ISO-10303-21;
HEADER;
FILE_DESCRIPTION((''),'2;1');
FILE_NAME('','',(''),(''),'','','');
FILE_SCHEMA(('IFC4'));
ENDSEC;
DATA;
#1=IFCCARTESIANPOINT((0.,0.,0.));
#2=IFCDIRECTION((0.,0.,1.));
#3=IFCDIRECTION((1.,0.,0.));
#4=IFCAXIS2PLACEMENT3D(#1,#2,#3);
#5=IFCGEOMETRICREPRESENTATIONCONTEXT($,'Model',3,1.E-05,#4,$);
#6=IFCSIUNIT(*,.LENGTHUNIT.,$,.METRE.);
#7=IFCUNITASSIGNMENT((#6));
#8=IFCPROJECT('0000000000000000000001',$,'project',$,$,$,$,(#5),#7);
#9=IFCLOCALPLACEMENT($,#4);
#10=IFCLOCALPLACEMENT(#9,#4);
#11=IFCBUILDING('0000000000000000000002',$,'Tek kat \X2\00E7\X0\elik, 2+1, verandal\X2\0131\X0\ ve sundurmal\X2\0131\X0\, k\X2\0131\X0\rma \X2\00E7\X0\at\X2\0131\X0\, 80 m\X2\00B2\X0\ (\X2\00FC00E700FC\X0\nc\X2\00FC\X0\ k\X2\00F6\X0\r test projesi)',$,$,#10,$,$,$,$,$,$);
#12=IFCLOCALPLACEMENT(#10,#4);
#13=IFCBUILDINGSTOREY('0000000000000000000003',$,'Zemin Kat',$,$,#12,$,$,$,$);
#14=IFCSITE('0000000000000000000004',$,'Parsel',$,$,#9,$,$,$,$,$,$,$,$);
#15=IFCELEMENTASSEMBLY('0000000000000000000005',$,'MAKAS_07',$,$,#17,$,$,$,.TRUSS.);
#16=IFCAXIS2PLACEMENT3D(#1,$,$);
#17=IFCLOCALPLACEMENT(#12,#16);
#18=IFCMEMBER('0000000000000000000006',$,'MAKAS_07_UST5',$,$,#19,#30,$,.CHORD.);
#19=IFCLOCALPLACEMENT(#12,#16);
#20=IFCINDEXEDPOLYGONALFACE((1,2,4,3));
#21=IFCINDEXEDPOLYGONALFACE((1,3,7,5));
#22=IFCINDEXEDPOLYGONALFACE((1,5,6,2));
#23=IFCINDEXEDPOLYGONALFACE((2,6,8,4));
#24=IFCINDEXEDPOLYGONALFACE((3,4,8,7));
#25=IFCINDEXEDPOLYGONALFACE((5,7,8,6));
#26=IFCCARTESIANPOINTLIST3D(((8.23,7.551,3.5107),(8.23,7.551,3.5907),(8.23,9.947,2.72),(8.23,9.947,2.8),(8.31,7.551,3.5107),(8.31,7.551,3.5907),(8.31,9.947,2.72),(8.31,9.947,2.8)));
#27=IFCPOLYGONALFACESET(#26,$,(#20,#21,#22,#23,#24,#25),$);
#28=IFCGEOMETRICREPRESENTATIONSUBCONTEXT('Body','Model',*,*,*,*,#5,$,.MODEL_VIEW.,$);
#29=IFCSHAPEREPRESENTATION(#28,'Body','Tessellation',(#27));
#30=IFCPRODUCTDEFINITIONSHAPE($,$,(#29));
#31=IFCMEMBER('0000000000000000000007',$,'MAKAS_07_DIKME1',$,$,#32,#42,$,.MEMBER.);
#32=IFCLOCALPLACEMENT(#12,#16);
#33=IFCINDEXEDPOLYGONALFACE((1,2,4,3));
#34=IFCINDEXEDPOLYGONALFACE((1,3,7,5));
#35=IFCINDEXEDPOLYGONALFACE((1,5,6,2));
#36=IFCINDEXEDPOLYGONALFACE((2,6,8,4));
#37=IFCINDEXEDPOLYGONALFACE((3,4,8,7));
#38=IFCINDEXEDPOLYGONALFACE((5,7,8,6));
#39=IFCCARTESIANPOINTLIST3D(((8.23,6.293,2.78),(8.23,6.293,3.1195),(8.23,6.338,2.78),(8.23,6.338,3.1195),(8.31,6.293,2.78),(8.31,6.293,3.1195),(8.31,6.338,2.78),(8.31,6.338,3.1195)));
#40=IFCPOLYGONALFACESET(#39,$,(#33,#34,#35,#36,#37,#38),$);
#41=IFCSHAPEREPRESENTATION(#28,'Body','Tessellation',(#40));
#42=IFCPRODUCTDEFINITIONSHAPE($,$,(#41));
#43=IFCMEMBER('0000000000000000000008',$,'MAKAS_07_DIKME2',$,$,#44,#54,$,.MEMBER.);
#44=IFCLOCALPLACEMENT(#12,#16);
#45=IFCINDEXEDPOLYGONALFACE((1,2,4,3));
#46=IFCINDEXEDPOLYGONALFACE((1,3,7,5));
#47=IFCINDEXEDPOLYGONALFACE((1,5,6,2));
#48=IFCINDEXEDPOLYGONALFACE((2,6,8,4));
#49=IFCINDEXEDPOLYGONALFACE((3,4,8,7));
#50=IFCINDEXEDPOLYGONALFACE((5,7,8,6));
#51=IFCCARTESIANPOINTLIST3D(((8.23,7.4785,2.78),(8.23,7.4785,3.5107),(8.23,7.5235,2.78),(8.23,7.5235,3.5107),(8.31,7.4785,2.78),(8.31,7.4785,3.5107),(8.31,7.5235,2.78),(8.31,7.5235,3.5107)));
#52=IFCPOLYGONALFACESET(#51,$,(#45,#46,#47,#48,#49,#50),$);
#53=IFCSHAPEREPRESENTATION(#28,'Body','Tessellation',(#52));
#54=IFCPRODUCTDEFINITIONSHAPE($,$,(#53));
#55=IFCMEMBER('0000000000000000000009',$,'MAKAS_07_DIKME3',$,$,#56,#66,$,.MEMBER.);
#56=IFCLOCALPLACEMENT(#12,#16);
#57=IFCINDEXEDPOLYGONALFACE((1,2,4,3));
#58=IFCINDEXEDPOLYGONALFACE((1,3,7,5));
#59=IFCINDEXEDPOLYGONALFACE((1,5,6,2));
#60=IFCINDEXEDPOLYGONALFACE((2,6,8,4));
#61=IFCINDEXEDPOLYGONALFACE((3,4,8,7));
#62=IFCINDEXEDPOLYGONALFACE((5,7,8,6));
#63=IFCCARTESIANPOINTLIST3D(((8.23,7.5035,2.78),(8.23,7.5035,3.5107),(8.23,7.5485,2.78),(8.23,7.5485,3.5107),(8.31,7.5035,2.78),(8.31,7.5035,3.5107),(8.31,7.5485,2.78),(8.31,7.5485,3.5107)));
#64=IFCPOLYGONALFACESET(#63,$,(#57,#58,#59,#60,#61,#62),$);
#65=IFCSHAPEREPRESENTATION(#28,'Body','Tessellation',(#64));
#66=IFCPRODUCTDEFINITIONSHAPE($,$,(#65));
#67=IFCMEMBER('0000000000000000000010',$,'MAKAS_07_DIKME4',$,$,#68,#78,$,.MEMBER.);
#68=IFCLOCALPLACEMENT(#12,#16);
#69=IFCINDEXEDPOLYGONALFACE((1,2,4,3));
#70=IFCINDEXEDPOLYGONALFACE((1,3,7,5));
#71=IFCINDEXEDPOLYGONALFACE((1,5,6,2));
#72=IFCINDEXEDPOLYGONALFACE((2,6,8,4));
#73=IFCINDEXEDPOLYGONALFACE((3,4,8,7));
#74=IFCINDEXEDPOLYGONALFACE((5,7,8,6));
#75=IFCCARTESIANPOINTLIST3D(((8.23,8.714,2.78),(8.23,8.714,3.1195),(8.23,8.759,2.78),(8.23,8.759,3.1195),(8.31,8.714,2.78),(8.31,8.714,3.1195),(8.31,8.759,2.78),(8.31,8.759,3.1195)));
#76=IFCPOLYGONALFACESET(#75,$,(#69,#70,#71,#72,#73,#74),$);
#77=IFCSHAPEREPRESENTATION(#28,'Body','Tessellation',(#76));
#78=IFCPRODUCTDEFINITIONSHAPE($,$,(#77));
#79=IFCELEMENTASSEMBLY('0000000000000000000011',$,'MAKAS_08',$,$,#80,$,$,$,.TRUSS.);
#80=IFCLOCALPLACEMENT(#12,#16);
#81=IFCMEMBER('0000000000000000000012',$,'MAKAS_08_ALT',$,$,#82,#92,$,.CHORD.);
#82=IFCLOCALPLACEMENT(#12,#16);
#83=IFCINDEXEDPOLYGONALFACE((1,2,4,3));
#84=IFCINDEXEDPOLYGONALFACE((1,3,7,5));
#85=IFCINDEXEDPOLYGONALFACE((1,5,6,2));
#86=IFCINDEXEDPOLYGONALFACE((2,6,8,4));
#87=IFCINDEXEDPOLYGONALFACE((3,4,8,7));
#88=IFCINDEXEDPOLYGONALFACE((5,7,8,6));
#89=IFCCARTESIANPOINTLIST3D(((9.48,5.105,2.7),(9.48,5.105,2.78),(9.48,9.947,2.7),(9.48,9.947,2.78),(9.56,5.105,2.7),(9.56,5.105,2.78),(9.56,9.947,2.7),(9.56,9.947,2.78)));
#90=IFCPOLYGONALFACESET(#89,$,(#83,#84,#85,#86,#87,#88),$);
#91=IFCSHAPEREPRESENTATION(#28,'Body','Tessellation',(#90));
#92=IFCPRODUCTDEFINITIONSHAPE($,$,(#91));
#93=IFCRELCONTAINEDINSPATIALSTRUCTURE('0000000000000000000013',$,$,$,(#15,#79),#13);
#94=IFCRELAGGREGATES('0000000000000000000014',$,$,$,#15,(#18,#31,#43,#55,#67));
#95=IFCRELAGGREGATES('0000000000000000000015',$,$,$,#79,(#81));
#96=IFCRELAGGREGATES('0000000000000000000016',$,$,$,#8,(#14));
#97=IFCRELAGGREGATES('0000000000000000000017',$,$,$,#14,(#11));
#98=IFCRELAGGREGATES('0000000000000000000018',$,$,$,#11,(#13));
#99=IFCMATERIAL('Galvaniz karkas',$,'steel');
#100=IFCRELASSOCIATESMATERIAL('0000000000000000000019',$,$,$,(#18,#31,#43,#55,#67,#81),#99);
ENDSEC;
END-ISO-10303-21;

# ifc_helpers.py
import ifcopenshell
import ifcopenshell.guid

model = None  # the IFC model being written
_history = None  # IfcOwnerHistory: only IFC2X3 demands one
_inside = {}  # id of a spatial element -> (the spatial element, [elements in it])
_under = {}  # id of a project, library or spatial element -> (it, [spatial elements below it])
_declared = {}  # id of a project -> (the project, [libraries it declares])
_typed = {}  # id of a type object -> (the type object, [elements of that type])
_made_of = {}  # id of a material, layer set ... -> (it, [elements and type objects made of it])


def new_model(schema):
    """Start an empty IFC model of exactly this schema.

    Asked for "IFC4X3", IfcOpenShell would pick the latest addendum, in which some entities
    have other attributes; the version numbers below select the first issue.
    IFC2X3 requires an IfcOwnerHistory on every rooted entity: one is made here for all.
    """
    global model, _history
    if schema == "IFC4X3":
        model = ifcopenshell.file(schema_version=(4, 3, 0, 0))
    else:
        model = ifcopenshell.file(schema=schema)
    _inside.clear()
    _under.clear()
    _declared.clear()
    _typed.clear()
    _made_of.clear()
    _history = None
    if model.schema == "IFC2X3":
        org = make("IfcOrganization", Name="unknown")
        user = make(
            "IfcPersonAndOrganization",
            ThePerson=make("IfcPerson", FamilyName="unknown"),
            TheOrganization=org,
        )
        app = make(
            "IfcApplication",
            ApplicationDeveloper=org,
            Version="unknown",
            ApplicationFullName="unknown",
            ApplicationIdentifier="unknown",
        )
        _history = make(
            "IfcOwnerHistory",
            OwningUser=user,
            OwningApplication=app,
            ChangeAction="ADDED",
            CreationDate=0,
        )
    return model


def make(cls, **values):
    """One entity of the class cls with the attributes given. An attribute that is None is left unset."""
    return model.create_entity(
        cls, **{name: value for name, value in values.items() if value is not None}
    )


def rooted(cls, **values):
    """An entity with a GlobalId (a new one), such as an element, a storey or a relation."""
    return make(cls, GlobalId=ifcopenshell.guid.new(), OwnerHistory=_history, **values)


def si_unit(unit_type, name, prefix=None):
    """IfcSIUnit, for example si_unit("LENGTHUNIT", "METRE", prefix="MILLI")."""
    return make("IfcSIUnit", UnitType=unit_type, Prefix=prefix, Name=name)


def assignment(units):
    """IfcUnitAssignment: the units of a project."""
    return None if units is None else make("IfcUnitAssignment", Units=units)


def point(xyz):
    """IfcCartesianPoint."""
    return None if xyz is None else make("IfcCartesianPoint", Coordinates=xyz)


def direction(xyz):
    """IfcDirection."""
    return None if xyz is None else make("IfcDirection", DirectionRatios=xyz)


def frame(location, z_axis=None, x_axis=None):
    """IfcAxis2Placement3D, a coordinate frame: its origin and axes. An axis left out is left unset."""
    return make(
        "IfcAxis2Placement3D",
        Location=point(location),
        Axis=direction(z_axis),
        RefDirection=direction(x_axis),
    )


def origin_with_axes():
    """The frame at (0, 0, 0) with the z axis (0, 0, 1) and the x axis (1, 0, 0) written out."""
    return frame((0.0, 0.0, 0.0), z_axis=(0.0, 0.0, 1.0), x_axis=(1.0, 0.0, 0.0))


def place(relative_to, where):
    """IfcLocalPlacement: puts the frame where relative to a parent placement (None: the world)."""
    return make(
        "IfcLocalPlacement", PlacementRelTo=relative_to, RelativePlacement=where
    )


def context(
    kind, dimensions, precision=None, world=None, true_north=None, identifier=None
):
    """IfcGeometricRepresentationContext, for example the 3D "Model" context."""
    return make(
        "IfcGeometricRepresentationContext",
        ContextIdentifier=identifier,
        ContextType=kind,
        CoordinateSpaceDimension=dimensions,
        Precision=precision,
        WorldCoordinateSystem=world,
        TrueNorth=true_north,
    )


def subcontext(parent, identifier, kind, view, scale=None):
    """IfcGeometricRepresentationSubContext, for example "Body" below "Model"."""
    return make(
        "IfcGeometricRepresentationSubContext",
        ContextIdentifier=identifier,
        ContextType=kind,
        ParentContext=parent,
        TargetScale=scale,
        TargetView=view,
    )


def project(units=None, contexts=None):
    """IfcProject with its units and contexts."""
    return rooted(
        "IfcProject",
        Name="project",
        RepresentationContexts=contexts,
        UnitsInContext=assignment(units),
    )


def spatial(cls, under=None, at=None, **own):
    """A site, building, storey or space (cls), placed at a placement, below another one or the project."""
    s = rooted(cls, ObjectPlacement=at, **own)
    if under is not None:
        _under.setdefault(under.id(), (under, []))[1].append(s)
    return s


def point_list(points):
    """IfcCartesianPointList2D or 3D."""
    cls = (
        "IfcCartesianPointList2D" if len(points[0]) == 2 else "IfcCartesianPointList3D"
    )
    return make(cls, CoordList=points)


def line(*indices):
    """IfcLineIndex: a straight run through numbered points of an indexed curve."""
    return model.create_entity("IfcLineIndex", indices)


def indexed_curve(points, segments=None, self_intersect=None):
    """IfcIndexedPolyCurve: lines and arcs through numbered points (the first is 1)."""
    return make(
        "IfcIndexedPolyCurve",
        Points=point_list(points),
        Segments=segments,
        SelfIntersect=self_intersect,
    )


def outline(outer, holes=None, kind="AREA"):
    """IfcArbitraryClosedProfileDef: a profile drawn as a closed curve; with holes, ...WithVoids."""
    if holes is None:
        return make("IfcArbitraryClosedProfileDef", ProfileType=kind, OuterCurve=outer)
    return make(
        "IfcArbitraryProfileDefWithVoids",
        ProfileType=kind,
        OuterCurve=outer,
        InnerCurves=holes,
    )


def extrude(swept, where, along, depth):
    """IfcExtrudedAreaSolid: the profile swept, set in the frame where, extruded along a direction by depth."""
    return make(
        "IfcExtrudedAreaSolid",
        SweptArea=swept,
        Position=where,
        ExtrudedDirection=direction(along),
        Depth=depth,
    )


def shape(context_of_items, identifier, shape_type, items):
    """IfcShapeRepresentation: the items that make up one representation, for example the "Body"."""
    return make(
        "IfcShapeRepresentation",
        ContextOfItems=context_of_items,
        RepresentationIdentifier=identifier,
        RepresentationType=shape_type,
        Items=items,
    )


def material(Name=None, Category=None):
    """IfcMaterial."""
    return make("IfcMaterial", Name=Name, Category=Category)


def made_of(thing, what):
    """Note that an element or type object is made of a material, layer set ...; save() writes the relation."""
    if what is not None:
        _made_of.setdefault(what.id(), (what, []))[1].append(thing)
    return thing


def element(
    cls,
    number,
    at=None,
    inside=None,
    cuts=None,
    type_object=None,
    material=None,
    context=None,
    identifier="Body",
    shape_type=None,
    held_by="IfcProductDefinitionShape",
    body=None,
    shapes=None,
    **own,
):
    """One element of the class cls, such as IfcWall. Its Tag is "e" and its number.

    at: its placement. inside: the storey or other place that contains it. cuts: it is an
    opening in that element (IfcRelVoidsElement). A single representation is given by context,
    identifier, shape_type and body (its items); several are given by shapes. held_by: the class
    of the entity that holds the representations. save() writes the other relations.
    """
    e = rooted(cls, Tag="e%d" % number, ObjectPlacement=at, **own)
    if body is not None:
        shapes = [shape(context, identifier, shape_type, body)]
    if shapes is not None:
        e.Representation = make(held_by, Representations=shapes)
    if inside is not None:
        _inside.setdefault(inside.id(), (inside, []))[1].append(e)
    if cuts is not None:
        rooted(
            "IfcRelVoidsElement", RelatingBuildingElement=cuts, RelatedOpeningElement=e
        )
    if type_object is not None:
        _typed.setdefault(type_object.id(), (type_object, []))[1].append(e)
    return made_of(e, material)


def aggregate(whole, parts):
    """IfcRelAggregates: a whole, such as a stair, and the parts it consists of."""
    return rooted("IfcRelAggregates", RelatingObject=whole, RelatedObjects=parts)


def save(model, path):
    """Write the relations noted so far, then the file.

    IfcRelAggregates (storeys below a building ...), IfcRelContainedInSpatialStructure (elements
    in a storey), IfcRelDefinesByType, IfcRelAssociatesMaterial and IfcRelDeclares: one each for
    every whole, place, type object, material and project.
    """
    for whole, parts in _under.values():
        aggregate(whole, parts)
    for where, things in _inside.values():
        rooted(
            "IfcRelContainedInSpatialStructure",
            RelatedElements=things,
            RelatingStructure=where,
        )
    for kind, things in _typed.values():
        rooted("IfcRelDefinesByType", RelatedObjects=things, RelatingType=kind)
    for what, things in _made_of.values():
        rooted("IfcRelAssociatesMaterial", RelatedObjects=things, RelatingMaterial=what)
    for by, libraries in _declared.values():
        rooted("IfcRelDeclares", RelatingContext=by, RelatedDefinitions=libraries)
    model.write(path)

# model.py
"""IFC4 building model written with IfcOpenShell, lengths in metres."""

from ifc_helpers import new_model, si_unit, frame, origin_with_axes, place, context, subcontext, project, spatial, line, indexed_curve, outline, extrude, material, element, aggregate, save


model = new_model("IFC4")

# Units and contexts
model_context = context("Model", 3, precision=1e-05, world=origin_with_axes())
body_context = subcontext(model_context, "Body", "Model", "MODEL_VIEW")
ifc_project = project(units=[si_unit("LENGTHUNIT", "METRE")], contexts=[model_context])

# Site, building, storey
site_placement = place(None, origin_with_axes())
site = spatial("IfcSite", under=ifc_project, at=site_placement, Name="Parsel")
building_placement = place(site_placement, origin_with_axes())
building = spatial("IfcBuilding", under=site, at=building_placement, Name="Tek kat çelik, 2+1, verandalı ve sundurmalı, kırma çatı, 80 m² (üçüncü kör test projesi)")
storey_placement = place(building_placement, origin_with_axes())
storey = spatial("IfcBuildingStorey", under=building, at=storey_placement, Name="Zemin Kat")

# Element assembly, members
ifc_material = material(Name="Galvaniz karkas", Category="steel")
assembly_1_placement = place(storey_placement, origin_with_axes())
assembly_1 = element("IfcElementAssembly", 1, at=assembly_1_placement, inside=storey, Name="MAKAS_07", PredefinedType="TRUSS")
member_1_placement = place(assembly_1_placement, origin_with_axes())
member_1 = element("IfcMember", 2, at=member_1_placement, material=ifc_material, Name="MAKAS_07_UST5", PredefinedType="CHORD", context=body_context, shape_type="SweptSolid", body=[
    extrude(outline(indexed_curve([(7.551, 3.5107), (9.947, 2.72), (9.947, 2.8), (7.551, 3.5907)], segments=[line(1, 2, 3, 4, 1)])), frame((8.23, 0.0, 0.0), z_axis=(1.0, 0.0, 0.0), x_axis=(0.0, 1.0, 0.0)), (0.0, 0.0, 1.0), 0.08),
])
member_2_placement = place(assembly_1_placement, origin_with_axes())
member_2 = element("IfcMember", 3, at=member_2_placement, material=ifc_material, Name="MAKAS_07_DIKME1", PredefinedType="MEMBER", context=body_context, shape_type="SweptSolid", body=[
    extrude(outline(indexed_curve([(6.293, 2.78), (6.338, 2.78), (6.338, 3.1195), (6.293, 3.1195)], segments=[line(1, 2, 3, 4, 1)])), frame((8.23, 0.0, 0.0), z_axis=(1.0, 0.0, 0.0), x_axis=(0.0, 1.0, 0.0)), (0.0, 0.0, 1.0), 0.08),
])
member_3_placement = place(assembly_1_placement, origin_with_axes())
member_3 = element("IfcMember", 4, at=member_3_placement, material=ifc_material, Name="MAKAS_07_DIKME2", PredefinedType="MEMBER", context=body_context, shape_type="SweptSolid", body=[
    extrude(outline(indexed_curve([(7.4785, 2.78), (7.5235, 2.78), (7.5235, 3.5107), (7.4785, 3.5107)], segments=[line(1, 2, 3, 4, 1)])), frame((8.23, 0.0, 0.0), z_axis=(1.0, 0.0, 0.0), x_axis=(0.0, 1.0, 0.0)), (0.0, 0.0, 1.0), 0.08),
])
member_4_placement = place(assembly_1_placement, origin_with_axes())
member_4 = element("IfcMember", 5, at=member_4_placement, material=ifc_material, Name="MAKAS_07_DIKME3", PredefinedType="MEMBER", context=body_context, shape_type="SweptSolid", body=[
    extrude(outline(indexed_curve([(7.5035, 2.78), (7.5485, 2.78), (7.5485, 3.5107), (7.5035, 3.5107)], segments=[line(1, 2, 3, 4, 1)])), frame((8.23, 0.0, 0.0), z_axis=(1.0, 0.0, 0.0), x_axis=(0.0, 1.0, 0.0)), (0.0, 0.0, 1.0), 0.08),
])
member_5_placement = place(assembly_1_placement, origin_with_axes())
member_5 = element("IfcMember", 6, at=member_5_placement, material=ifc_material, Name="MAKAS_07_DIKME4", PredefinedType="MEMBER", context=body_context, shape_type="SweptSolid", body=[
    extrude(outline(indexed_curve([(8.714, 2.78), (8.759, 2.78), (8.759, 3.1195), (8.714, 3.1195)], segments=[line(1, 2, 3, 4, 1)])), frame((8.23, 0.0, 0.0), z_axis=(1.0, 0.0, 0.0), x_axis=(0.0, 1.0, 0.0)), (0.0, 0.0, 1.0), 0.08),
])
aggregate(assembly_1, [member_1, member_2, member_3, member_4, member_5])

# Element assembly, member
assembly_2_placement = place(storey_placement, origin_with_axes())
assembly_2 = element("IfcElementAssembly", 7, at=assembly_2_placement, inside=storey, Name="MAKAS_08", PredefinedType="TRUSS")
member_6_placement = place(assembly_2_placement, origin_with_axes())
member_6 = element("IfcMember", 8, at=member_6_placement, material=ifc_material, Name="MAKAS_08_ALT", PredefinedType="CHORD", context=body_context, shape_type="SweptSolid", body=[
    extrude(outline(indexed_curve([(5.105, 2.7), (9.947, 2.7), (9.947, 2.78), (5.105, 2.78)], segments=[line(1, 2, 3, 4, 1)])), frame((9.48, 0.0, 0.0), z_axis=(1.0, 0.0, 0.0), x_axis=(0.0, 1.0, 0.0)), (0.0, 0.0, 1.0), 0.08),
])
aggregate(assembly_2, [member_6])

save(model, "model.ifc")
